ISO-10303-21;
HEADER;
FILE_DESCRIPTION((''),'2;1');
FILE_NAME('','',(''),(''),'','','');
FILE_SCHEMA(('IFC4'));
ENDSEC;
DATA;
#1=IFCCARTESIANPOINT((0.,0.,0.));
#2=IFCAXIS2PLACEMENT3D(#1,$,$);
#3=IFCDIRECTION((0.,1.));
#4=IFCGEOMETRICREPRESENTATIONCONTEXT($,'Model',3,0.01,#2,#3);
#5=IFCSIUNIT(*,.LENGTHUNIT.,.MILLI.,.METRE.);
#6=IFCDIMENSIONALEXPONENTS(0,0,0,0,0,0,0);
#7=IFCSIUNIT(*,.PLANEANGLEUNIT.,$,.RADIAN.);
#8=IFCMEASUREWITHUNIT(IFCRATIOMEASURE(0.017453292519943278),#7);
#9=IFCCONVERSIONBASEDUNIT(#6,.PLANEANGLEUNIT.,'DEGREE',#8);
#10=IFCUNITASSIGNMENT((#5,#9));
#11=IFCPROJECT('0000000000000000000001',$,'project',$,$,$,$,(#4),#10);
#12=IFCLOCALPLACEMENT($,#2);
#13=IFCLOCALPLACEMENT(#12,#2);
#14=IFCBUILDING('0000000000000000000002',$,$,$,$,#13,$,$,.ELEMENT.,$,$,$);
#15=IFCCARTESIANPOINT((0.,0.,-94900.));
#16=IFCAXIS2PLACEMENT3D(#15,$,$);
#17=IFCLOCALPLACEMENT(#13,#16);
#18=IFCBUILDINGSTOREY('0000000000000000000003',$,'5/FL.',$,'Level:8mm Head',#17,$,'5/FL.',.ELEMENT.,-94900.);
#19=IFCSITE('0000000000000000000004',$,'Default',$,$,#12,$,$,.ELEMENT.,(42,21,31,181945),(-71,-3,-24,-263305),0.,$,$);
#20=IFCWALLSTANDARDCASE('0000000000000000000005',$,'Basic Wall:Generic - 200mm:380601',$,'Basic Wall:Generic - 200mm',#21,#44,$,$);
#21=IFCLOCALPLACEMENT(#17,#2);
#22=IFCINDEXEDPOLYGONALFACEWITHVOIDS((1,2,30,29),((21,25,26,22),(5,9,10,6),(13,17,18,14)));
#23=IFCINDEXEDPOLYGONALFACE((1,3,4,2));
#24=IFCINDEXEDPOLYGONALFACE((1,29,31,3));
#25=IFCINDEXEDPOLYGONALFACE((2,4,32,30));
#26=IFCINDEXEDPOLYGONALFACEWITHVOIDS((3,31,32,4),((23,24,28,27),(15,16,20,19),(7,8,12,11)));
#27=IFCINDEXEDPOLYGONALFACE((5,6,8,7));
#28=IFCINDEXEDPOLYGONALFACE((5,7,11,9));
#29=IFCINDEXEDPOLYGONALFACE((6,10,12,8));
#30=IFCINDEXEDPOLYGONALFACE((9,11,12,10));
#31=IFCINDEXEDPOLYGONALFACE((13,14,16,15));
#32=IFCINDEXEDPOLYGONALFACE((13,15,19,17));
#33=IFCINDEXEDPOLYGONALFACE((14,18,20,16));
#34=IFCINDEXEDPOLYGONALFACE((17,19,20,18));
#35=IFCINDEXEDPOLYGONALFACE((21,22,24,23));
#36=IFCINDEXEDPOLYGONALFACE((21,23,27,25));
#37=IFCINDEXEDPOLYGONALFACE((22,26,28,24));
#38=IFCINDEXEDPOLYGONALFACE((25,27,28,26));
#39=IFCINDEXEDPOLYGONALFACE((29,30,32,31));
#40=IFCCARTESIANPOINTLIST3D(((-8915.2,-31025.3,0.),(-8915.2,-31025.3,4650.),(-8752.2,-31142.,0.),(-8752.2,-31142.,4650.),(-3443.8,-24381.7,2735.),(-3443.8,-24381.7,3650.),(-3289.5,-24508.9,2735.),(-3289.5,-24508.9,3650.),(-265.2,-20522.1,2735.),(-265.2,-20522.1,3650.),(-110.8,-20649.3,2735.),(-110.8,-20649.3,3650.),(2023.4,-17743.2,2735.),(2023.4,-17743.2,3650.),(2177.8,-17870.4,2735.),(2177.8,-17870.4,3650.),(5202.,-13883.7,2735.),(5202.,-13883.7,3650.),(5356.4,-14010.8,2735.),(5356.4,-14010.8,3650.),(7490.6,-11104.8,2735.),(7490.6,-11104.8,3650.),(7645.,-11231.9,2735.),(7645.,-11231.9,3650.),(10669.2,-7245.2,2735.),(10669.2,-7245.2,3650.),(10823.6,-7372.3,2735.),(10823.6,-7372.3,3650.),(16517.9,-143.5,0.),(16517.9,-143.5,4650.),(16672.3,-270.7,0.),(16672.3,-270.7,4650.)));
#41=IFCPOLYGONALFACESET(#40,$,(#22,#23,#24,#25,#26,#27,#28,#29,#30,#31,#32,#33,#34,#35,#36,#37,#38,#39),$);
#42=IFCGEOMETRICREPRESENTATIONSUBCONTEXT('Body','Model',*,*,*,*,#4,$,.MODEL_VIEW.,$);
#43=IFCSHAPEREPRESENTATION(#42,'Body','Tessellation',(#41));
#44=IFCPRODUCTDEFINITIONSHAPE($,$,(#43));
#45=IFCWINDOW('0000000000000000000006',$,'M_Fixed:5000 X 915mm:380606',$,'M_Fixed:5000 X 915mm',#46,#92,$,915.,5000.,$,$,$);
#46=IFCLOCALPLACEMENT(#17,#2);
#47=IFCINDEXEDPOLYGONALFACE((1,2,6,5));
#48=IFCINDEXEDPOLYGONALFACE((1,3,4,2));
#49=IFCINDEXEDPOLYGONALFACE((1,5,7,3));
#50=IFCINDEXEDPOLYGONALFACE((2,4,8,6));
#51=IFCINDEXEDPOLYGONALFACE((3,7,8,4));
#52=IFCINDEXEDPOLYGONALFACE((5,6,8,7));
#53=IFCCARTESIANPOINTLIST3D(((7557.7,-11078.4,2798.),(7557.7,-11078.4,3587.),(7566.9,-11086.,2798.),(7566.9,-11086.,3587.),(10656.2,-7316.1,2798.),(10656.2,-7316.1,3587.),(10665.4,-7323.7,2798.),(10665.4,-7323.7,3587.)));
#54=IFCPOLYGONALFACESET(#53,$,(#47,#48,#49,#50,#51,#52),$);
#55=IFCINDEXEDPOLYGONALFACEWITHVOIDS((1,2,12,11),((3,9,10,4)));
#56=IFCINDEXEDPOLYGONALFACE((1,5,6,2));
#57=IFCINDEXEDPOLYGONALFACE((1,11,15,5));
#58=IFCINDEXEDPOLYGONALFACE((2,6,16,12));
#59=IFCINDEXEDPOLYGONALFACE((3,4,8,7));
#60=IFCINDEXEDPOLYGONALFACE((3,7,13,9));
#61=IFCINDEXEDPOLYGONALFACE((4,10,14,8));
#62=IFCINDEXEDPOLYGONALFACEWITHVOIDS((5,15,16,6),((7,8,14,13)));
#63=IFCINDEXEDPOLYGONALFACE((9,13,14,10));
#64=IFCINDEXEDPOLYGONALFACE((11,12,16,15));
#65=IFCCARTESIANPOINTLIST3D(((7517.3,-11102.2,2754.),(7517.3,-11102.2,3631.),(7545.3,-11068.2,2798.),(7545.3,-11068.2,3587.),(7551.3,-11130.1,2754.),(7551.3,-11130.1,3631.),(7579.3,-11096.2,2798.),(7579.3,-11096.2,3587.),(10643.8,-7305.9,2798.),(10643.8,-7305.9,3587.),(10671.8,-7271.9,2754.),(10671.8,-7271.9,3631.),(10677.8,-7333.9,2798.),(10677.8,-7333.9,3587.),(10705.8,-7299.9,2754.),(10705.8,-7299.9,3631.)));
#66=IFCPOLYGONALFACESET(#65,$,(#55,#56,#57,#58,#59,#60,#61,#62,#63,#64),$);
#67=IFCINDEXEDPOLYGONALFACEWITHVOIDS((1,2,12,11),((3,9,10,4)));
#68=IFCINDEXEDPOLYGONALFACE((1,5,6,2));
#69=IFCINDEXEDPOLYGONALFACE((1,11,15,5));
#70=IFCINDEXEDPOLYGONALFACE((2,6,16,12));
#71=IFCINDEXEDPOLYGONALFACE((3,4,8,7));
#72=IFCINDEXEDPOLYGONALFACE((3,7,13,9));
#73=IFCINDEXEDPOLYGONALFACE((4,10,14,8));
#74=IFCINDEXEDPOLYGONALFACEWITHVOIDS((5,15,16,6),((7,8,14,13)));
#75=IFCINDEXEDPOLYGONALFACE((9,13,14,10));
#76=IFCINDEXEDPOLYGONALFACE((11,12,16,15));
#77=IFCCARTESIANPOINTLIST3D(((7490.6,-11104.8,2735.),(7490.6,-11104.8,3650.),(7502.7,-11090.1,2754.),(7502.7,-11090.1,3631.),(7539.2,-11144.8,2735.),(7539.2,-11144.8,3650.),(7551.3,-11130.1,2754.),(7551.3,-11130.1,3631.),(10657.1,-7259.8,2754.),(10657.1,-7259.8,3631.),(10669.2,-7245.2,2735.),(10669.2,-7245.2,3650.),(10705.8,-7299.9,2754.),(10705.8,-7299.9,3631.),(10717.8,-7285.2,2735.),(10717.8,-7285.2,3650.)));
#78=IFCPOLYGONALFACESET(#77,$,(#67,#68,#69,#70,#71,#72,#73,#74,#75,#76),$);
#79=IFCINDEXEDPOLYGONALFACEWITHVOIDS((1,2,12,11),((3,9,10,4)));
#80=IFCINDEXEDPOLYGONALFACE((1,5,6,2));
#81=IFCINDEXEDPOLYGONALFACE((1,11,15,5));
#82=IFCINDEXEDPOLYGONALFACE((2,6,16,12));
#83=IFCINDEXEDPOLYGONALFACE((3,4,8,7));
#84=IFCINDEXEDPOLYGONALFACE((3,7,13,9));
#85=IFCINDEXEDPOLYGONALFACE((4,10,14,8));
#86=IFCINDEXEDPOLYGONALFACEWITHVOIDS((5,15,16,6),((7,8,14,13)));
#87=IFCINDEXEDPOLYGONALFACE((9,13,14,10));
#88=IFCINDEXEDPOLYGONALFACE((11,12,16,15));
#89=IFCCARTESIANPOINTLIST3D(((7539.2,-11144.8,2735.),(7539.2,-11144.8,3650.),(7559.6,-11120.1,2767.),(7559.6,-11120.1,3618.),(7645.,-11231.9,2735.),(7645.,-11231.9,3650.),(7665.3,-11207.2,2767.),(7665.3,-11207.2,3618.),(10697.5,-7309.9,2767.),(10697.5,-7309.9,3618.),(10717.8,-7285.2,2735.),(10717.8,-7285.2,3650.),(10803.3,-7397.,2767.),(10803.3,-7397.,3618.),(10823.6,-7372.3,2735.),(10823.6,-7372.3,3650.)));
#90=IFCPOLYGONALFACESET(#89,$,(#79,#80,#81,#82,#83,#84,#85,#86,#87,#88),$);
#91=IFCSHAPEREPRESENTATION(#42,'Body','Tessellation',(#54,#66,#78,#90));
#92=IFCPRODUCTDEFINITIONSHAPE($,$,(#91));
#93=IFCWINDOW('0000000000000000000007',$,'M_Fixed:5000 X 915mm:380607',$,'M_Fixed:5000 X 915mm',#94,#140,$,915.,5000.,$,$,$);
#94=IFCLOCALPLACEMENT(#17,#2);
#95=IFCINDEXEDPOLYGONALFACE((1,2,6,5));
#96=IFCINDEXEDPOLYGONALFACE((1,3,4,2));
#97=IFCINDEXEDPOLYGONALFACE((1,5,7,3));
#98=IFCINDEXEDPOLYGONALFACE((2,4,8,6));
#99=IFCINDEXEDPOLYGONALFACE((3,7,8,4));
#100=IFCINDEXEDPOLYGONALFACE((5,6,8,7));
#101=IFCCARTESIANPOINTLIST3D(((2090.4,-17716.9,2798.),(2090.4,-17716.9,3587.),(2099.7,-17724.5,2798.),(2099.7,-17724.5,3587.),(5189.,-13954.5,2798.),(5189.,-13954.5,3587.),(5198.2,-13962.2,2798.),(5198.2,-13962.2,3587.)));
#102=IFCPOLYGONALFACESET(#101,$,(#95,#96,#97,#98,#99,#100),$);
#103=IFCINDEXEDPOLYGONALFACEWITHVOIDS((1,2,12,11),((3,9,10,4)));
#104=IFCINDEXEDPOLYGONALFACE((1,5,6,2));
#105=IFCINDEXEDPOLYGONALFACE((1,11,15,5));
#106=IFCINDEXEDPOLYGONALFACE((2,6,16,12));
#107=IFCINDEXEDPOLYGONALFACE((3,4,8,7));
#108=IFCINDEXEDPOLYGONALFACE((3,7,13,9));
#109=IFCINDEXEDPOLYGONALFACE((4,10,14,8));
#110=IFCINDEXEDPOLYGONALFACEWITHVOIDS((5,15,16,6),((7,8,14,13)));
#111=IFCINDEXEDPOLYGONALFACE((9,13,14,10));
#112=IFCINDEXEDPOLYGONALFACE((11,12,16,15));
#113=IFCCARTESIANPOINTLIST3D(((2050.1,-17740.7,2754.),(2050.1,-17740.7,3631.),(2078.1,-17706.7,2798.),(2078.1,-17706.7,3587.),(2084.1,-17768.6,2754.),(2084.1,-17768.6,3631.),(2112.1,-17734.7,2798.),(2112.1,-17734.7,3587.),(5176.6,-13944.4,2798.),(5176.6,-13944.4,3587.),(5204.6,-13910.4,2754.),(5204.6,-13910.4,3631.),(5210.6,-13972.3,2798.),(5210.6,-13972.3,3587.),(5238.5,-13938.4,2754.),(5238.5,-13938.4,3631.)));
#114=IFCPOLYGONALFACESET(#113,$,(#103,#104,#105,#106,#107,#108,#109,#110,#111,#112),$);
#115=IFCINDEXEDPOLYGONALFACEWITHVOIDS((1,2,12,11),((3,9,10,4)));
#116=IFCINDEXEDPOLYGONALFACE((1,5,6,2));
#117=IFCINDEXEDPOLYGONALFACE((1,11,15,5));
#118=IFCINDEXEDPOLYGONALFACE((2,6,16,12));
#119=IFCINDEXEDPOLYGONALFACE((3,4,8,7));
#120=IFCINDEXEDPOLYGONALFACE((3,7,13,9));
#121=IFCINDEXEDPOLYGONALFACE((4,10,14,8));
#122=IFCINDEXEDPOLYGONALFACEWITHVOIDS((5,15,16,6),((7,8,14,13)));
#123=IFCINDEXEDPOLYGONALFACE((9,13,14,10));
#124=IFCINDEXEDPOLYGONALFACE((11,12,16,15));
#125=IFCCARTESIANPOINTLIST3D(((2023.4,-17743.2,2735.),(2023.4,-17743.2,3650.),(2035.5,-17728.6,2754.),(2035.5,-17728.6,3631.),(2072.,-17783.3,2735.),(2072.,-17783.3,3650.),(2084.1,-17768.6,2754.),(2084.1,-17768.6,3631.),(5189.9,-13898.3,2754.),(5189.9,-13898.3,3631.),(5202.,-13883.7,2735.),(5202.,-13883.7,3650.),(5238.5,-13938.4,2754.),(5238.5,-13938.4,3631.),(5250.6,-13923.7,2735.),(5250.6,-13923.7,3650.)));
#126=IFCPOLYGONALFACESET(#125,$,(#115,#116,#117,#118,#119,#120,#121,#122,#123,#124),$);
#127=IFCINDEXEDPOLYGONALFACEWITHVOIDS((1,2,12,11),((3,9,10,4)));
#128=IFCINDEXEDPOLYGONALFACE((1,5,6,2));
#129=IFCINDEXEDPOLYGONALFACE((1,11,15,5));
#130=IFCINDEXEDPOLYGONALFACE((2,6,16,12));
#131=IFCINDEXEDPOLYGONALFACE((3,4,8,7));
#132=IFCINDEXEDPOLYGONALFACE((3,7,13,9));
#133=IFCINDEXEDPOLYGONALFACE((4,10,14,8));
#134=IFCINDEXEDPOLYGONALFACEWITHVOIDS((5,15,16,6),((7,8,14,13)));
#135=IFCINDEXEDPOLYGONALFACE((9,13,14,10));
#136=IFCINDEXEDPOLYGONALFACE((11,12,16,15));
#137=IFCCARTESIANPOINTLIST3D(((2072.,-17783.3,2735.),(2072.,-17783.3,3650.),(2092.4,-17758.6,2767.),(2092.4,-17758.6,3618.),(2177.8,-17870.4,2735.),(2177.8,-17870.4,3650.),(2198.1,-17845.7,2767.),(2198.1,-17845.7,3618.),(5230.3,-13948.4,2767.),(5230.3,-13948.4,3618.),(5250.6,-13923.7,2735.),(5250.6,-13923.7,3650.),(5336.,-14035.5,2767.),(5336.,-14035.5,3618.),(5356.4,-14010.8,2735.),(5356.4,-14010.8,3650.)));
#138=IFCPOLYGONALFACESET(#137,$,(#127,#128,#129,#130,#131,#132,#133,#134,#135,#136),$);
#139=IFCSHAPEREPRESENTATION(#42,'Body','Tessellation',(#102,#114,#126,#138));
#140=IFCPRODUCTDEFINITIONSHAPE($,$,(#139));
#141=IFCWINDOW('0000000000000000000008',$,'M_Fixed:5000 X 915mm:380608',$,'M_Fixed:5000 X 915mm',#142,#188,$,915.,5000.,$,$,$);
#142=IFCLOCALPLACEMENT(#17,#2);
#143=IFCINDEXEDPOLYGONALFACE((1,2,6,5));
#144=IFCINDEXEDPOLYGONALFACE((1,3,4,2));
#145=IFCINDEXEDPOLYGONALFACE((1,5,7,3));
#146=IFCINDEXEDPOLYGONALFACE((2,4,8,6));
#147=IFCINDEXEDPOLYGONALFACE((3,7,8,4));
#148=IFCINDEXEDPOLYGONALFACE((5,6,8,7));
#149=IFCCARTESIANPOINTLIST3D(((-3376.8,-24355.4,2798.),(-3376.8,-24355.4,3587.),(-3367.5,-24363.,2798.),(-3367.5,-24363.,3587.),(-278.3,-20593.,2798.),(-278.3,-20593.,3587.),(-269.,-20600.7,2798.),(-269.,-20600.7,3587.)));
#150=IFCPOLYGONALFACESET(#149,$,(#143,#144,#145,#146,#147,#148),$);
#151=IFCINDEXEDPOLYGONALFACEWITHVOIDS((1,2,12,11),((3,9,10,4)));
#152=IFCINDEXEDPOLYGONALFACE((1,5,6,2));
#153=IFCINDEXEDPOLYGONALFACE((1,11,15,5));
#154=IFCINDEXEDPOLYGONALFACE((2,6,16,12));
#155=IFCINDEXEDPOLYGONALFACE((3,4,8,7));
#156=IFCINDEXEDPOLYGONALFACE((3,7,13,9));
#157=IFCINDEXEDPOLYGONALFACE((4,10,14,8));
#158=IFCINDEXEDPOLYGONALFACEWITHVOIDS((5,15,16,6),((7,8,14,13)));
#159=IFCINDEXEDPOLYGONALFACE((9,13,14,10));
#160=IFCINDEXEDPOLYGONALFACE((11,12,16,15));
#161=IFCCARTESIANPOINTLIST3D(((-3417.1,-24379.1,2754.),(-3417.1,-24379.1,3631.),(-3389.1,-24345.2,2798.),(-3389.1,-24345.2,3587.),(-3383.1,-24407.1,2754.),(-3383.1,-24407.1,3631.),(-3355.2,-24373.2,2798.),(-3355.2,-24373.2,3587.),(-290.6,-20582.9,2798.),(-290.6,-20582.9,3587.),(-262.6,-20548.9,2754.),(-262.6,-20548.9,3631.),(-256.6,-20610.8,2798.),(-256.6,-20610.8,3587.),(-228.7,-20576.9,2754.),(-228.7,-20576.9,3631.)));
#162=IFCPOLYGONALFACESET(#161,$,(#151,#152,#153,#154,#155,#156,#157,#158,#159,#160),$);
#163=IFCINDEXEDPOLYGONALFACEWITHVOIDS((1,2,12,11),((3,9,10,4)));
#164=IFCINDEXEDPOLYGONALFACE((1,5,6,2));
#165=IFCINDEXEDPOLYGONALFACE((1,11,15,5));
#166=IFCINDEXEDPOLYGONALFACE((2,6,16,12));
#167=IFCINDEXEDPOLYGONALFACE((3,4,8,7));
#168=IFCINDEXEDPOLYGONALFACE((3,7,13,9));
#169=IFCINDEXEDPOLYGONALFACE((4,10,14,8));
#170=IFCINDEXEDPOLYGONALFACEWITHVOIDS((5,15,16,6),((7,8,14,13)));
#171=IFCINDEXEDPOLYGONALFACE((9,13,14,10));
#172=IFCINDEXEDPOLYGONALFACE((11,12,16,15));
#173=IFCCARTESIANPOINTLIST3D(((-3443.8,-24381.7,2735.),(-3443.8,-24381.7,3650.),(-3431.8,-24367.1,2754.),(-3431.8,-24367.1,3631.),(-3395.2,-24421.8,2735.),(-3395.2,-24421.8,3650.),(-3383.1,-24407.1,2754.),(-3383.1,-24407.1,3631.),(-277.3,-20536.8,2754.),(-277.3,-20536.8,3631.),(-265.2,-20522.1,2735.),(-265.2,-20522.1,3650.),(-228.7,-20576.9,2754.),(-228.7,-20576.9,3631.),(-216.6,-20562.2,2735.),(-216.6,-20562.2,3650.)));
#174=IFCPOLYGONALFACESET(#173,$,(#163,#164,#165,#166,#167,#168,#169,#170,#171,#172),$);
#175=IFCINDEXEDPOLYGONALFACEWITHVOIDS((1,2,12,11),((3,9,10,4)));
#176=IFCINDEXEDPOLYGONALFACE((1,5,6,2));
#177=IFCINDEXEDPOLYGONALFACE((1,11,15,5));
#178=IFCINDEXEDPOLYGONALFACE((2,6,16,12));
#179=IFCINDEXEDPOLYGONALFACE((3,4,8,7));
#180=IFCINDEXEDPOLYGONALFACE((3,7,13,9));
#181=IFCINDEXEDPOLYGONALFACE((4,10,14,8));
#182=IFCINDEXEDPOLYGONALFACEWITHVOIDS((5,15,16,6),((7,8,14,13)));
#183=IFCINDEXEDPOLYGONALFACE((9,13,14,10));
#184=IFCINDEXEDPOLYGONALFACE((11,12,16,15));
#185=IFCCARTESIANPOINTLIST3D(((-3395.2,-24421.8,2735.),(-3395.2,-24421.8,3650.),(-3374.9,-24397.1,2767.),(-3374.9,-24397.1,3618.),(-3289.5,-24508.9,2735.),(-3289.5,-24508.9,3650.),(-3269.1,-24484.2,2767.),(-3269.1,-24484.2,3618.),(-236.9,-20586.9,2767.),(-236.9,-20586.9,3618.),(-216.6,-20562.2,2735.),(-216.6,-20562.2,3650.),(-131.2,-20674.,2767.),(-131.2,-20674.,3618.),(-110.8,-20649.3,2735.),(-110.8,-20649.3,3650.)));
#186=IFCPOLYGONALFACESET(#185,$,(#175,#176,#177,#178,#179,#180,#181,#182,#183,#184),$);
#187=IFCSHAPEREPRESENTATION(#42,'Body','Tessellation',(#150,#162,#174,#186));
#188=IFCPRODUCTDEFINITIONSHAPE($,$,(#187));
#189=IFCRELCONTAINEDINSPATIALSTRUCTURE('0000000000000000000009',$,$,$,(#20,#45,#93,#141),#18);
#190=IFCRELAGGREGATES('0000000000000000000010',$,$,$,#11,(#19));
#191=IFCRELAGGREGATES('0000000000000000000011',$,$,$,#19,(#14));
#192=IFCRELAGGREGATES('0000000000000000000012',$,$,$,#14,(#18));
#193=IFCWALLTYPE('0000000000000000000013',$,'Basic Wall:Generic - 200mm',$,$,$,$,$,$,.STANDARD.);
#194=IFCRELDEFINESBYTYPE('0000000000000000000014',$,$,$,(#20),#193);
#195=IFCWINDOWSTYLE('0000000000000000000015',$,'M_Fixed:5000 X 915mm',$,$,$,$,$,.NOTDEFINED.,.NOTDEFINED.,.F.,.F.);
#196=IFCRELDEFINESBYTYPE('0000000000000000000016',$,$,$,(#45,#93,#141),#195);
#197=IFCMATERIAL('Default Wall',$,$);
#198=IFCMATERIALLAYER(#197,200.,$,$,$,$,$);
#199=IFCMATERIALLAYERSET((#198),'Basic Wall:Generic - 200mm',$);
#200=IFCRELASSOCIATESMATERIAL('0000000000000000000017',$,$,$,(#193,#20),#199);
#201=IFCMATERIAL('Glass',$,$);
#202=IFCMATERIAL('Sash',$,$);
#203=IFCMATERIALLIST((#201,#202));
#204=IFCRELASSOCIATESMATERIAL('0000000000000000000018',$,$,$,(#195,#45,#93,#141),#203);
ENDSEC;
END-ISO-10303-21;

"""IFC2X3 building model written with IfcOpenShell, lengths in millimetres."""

from ifc_helpers import new_model, entity, si_unit, converted_unit, direction, frame, frame_2d, origin, place, context, subcontext, project, spatial, polyline, rectangle, outline, extrude, source, transform, mapped, material, material_list, layer, layer_set, layer_usage, type_object, type_shapes, element, fill, save


model = new_model("IFC2X3")

# Units and contexts
model_context = context("Model", 3, precision=0.01, world=origin(), true_north=direction((0.0, 1.0)))
body_context = subcontext(model_context, "Body", "Model", "MODEL_VIEW")
ifc_project = project(units=[si_unit("LENGTHUNIT", "METRE", prefix="MILLI"), converted_unit("PLANEANGLEUNIT", "DEGREE", entity("IfcRatioMeasure", 0.017453292519943278), si_unit("PLANEANGLEUNIT", "RADIAN"), dimensions=[0, 0, 0, 0, 0, 0, 0])], contexts=[model_context])

# Site, building, storey
site_placement = place(None, origin())
site = spatial("IfcSite", under=ifc_project, at=site_placement, Name="Default", CompositionType="ELEMENT", RefLatitude=(42, 21, 31, 181945), RefLongitude=(-71, -3, -24, -263305), RefElevation=0.0)
building_placement = place(site_placement, origin())
building = spatial("IfcBuilding", under=site, at=building_placement, CompositionType="ELEMENT")
storey_placement = place(building_placement, frame((0.0, 0.0, -94900.0)))
storey = spatial("IfcBuildingStorey", under=building, at=storey_placement, Name="5/FL.", ObjectType="Level:8mm Head", LongName="5/FL.", CompositionType="ELEMENT", Elevation=-94900.0)

# Shared definitions
ifc_material_1 = material(Name="Default Wall")
ifc_layer = layer(ifc_material_1, 200.0)
ifc_layer_set = layer_set([ifc_layer], Name="Basic Wall:Generic - 200mm")
ifc_layer_usage = layer_usage(ifc_layer_set, "AXIS2", "NEGATIVE", 100.0)
wall_type = type_object("IfcWallType", Name="Basic Wall:Generic - 200mm", PredefinedType="STANDARD", material=ifc_layer_set)

# Wall, openings, windows
wall_1_placement = place(storey_placement, frame((17103.6, 410.4, 0.0), z_axis=(0.0, 0.0, 1.0), x_axis=(-0.635723, -0.771917, 0.0)))
wall_1 = element("IfcWallStandardCase", 1, at=wall_1_placement, inside=storey, type_object=wall_type, material=ifc_layer_usage, Name="Basic Wall:Generic - 200mm:380601", ObjectType="Basic Wall:Generic - 200mm", context=body_context, shape_type="SweptSolid", body=[
    extrude(outline(polyline([(40806.5, -100.0), (40793.0, 100.0), (37219.3, 100.0), (37019.3, 100.0), (800.0, 100.0), (800.0, -100.0), (37019.3, -100.0), (37219.3, -100.0), (40806.5, -100.0)])), origin(), (0.0, 0.0, 1.0), 4650.0),
])
opening_1_placement = place(wall_1_placement, origin())
element("IfcOpeningElement", 2, at=opening_1_placement, cuts=wall_1, ObjectType="Opening", context=body_context, shape_type="SweptSolid", body=[
    extrude(rectangle(XDim=1000.0, YDim=1012.7, at=frame_2d((0.0, 0.0), x_axis=(1.0, 0.0))), frame((293.7, -183.3, 500.0), z_axis=(0.0, 1.0, 0.0), x_axis=(0.0, 0.0, -1.0)), (0.0, 0.0, 1.0), 1010.1),
])
opening_2_placement = place(wall_1_placement, frame((15000.0, 100.0, 2735.0)))
opening_2 = element("IfcOpeningElement", 3, at=opening_2_placement, cuts=wall_1, ObjectType="Opening", context=body_context, shape_type="SweptSolid", body=[
    extrude(rectangle(XDim=915.0, YDim=5000.0, at=frame_2d((457.5, 2500.0), x_axis=(1.0, 0.0))), frame((0.0, 0.0, 0.0), z_axis=(0.0, -1.0, 0.0), x_axis=(0.0, 0.0, 1.0)), (0.0, 0.0, 1.0), 200.0),
])
opening_3_placement = place(wall_1_placement, frame((23600.0, 100.0, 2735.0)))
opening_3 = element("IfcOpeningElement", 4, at=opening_3_placement, cuts=wall_1, ObjectType="Opening", context=body_context, shape_type="SweptSolid", body=[
    extrude(rectangle(XDim=915.0, YDim=5000.0, at=frame_2d((457.5, 2500.0), x_axis=(1.0, 0.0))), frame((0.0, 0.0, 0.0), z_axis=(0.0, -1.0, 0.0), x_axis=(0.0, 0.0, 1.0)), (0.0, 0.0, 1.0), 200.0),
])
opening_4_placement = place(wall_1_placement, frame((32200.0, 100.0, 2735.0)))
opening_4 = element("IfcOpeningElement", 5, at=opening_4_placement, cuts=wall_1, ObjectType="Opening", context=body_context, shape_type="SweptSolid", body=[
    extrude(rectangle(XDim=915.0, YDim=5000.0, at=frame_2d((457.5, 2500.0), x_axis=(1.0, 0.0))), frame((0.0, 0.0, 0.0), z_axis=(0.0, -1.0, 0.0), x_axis=(0.0, 0.0, 1.0)), (0.0, 0.0, 1.0), 200.0),
])
ifc_material_2 = material(Name="Glass")
ifc_material_3 = material(Name="Sash")
ifc_material_list = material_list([ifc_material_2, ifc_material_3])
window_style_1 = type_object("IfcWindowStyle", Name="M_Fixed:5000 X 915mm", ConstructionType="NOTDEFINED", OperationType="NOTDEFINED", ParameterTakesPrecedence=False, Sizeable=False, material=ifc_material_list)
shared_shape_1 = source(origin(), body_context, "Body", "SweptSolid", [
    extrude(rectangle(XDim=12.0, YDim=4874.0, at=frame_2d((0.0, 0.0), x_axis=(1.0, 0.0))), frame((2500.0, 159.0, 63.0), z_axis=(0.0, 0.0, 1.0), x_axis=(0.0, -1.0, 0.0)), (0.0, 0.0, 1.0), 789.0),
    extrude(outline(polyline([(-2481.0, -438.5), (2481.0, -438.5), (2481.0, 438.5), (-2481.0, 438.5), (-2481.0, -438.5)]), holes=[polyline([(-2437.0, -394.5), (-2437.0, 394.5), (2437.0, 394.5), (2437.0, -394.5), (-2437.0, -394.5)])]), frame((2500.0, 137.0, 457.5), z_axis=(0.0, 1.0, 0.0), x_axis=(1.0, 0.0, 0.0)), (0.0, 0.0, 1.0), 44.0),
    extrude(outline(polyline([(-2500.0, -457.5), (2500.0, -457.5), (2500.0, 457.5), (-2500.0, 457.5), (-2500.0, -457.5)]), holes=[polyline([(-2481.0, -438.5), (-2481.0, 438.5), (2481.0, 438.5), (2481.0, -438.5), (-2481.0, -438.5)])]), frame((2500.0, 137.0, 457.5), z_axis=(0.0, 1.0, 0.0), x_axis=(1.0, 0.0, 0.0)), (0.0, 0.0, 1.0), 63.0),
    extrude(outline(polyline([(-2500.0, -457.5), (2500.0, -457.5), (2500.0, 457.5), (-2500.0, 457.5), (-2500.0, -457.5)]), holes=[polyline([(-2468.0, -425.5), (-2468.0, 425.5), (2468.0, 425.5), (2468.0, -425.5), (-2468.0, -425.5)])]), frame((2500.0, 0.0, 457.5), z_axis=(0.0, 1.0, 0.0), x_axis=(1.0, 0.0, 0.0)), (0.0, 0.0, 1.0), 137.0),
])
type_shapes(window_style_1, [shared_shape_1])
window_1_placement = place(opening_2_placement, frame((0.0, 0.0, 0.0), z_axis=(0.0, 0.0, 1.0), x_axis=(-1.0, 0.0, 0.0)))
window_1 = element("IfcWindow", 6, at=window_1_placement, inside=storey, type_object=window_style_1, material=ifc_material_list, Name="M_Fixed:5000 X 915mm:380606", ObjectType="M_Fixed:5000 X 915mm", OverallHeight=915.0, OverallWidth=5000.0, context=body_context, shape_type="MappedRepresentation", body=[
    mapped(shared_shape_1, transform((0.0, 0.0, 0.0), scale=1.0)),
])
fill(opening_2, window_1)
window_2_placement = place(opening_3_placement, frame((0.0, 0.0, 0.0), z_axis=(0.0, 0.0, 1.0), x_axis=(-1.0, 0.0, 0.0)))
window_2 = element("IfcWindow", 7, at=window_2_placement, inside=storey, type_object=window_style_1, material=ifc_material_list, Name="M_Fixed:5000 X 915mm:380607", ObjectType="M_Fixed:5000 X 915mm", OverallHeight=915.0, OverallWidth=5000.0, context=body_context, shape_type="MappedRepresentation", body=[
    mapped(shared_shape_1, transform((0.0, 0.0, 0.0), scale=1.0)),
])
fill(opening_3, window_2)
window_3_placement = place(opening_4_placement, frame((0.0, 0.0, 0.0), z_axis=(0.0, 0.0, 1.0), x_axis=(-1.0, 0.0, 0.0)))
window_3 = element("IfcWindow", 8, at=window_3_placement, inside=storey, type_object=window_style_1, material=ifc_material_list, Name="M_Fixed:5000 X 915mm:380608", ObjectType="M_Fixed:5000 X 915mm", OverallHeight=915.0, OverallWidth=5000.0, context=body_context, shape_type="MappedRepresentation", body=[
    mapped(shared_shape_1, transform((0.0, 0.0, 0.0), scale=1.0)),
])
fill(opening_4, window_3)

save(model, "model.ifc")
